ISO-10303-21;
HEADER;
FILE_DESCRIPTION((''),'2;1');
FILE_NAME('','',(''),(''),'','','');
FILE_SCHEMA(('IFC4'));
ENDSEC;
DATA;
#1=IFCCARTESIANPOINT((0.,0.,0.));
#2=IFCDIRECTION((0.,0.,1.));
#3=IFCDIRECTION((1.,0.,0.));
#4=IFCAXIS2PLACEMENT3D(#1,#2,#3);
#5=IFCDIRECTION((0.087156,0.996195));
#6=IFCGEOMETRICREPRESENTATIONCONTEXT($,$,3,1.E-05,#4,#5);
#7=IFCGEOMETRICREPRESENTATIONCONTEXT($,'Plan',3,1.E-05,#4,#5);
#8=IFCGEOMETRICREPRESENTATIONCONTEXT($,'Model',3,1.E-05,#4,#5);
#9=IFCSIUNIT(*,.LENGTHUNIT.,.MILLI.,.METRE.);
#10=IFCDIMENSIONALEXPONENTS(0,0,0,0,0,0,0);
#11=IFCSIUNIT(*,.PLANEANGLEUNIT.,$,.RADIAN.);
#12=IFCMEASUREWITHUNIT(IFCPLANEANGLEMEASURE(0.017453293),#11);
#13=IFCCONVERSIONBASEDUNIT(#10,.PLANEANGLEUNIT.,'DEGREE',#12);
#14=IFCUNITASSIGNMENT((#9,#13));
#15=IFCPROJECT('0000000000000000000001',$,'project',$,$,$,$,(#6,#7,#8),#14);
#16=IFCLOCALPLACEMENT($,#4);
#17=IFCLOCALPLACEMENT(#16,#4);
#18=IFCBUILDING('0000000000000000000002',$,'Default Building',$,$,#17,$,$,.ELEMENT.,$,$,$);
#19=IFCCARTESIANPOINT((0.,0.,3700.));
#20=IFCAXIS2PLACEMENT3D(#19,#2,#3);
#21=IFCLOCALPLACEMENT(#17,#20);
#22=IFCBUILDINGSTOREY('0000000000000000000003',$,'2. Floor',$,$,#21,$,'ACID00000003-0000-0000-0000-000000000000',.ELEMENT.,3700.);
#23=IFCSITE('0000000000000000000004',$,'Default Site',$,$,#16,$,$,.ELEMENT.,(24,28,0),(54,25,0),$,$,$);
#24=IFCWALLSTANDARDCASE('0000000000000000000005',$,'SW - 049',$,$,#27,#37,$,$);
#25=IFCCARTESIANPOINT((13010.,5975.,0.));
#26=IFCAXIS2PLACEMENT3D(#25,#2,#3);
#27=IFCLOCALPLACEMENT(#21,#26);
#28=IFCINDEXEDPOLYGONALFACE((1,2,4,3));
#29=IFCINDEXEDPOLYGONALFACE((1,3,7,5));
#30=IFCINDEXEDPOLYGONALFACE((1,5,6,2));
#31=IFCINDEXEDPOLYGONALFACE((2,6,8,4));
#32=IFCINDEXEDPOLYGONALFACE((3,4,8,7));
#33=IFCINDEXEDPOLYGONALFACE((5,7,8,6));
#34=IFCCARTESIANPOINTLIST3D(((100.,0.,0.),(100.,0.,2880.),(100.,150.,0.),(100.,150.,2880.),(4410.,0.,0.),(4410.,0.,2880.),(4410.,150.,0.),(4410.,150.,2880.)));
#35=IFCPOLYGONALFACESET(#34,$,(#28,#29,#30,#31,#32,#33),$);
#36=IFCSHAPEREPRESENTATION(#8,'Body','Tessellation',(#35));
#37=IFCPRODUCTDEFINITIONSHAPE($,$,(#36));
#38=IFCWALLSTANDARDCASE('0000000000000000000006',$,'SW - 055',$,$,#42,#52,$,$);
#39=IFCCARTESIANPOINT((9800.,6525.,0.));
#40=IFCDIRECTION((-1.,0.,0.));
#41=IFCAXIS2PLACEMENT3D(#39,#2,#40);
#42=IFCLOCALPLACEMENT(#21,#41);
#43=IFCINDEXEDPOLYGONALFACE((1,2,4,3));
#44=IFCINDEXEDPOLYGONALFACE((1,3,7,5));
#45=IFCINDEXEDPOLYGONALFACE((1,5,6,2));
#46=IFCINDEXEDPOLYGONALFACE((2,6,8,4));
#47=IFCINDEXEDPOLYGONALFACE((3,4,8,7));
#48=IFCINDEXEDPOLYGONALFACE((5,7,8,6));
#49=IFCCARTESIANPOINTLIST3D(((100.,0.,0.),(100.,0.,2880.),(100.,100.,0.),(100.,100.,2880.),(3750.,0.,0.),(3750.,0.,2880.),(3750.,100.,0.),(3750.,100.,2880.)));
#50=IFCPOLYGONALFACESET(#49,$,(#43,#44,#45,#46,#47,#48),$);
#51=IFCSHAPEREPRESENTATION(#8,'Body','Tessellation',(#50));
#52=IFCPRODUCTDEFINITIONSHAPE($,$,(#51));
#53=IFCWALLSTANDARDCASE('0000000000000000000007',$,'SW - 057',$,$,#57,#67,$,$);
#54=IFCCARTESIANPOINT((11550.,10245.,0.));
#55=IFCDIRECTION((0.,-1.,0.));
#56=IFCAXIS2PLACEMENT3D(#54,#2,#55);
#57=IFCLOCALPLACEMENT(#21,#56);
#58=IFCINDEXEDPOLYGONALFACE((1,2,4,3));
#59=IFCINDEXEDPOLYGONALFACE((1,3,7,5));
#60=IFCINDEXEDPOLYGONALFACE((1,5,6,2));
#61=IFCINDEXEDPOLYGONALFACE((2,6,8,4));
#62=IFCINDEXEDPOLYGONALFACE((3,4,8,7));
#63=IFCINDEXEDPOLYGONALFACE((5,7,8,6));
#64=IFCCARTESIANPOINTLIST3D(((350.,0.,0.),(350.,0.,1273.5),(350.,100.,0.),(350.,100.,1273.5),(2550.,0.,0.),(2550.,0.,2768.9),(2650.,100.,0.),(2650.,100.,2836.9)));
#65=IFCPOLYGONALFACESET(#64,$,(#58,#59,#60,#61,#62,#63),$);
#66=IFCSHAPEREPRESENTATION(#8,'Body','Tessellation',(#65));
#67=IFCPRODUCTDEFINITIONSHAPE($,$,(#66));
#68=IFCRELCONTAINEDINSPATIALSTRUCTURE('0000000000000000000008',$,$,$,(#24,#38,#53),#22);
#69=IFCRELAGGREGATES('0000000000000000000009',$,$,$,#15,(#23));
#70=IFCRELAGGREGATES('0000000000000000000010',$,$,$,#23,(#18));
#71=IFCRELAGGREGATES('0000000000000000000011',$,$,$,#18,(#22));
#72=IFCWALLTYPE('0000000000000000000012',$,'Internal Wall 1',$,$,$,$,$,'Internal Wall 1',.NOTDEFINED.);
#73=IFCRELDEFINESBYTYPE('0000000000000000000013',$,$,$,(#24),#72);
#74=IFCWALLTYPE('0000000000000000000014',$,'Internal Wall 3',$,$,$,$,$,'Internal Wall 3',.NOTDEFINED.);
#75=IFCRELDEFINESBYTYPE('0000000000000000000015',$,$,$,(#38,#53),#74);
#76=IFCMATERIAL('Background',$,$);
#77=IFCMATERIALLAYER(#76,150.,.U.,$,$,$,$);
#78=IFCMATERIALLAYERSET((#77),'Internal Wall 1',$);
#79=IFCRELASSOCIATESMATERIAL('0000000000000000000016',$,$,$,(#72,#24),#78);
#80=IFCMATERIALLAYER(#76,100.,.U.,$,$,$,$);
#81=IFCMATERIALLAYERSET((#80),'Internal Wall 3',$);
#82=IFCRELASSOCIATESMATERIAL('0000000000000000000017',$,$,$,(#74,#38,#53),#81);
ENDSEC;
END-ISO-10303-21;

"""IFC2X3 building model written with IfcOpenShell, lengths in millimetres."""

from ifc_helpers import new_model, entity, si_unit, converted_unit, direction, frame, origin_with_axes, place, context, project, spatial, polyline, outline, extrude, clip, halfspace, material, layer, layer_set, layer_usage, type_object, element, save


model = new_model("IFC2X3")

# Units and contexts
context_of_model = context(None, 3, precision=1e-05, world=origin_with_axes(), true_north=direction((0.087156, 0.996195)))
plan_context = context("Plan", 3, precision=1e-05, world=origin_with_axes(), true_north=direction((0.087156, 0.996195)))
model_context = context("Model", 3, precision=1e-05, world=origin_with_axes(), true_north=direction((0.087156, 0.996195)))
ifc_project = project(units=[si_unit("LENGTHUNIT", "METRE", prefix="MILLI"), converted_unit("PLANEANGLEUNIT", "DEGREE", entity("IfcPlaneAngleMeasure", 0.017453293), si_unit("PLANEANGLEUNIT", "RADIAN"), dimensions=[0, 0, 0, 0, 0, 0, 0])], contexts=[context_of_model, plan_context, model_context])

# Site, building, storey
site_placement = place(None, origin_with_axes())
site = spatial("IfcSite", under=ifc_project, at=site_placement, Name="Default Site", CompositionType="ELEMENT", RefLatitude=(24, 28, 0), RefLongitude=(54, 25, 0))
building_placement = place(site_placement, origin_with_axes())
building = spatial("IfcBuilding", under=site, at=building_placement, Name="Default Building", CompositionType="ELEMENT")
storey_placement = place(building_placement, frame((0.0, 0.0, 3700.0), z_axis=(0.0, 0.0, 1.0), x_axis=(1.0, 0.0, 0.0)))
storey = spatial("IfcBuildingStorey", under=building, at=storey_placement, Name="2. Floor", LongName="ACID00000003-0000-0000-0000-000000000000", CompositionType="ELEMENT", Elevation=3700.0)

# Shared definitions
ifc_material = material(Name="Background")

# Wall
ifc_layer_1 = layer(ifc_material, 150.0, ventilated="UNKNOWN")
ifc_layer_set_1 = layer_set([ifc_layer_1], Name="Internal Wall 1")
ifc_layer_usage_1 = layer_usage(ifc_layer_set_1, "AXIS2", "POSITIVE", 0.0)
wall_type_1 = type_object("IfcWallType", Name="Internal Wall 1", ElementType="Internal Wall 1", PredefinedType="NOTDEFINED", material=ifc_layer_set_1)
wall_1_placement = place(storey_placement, frame((13010.0, 5975.0, 0.0), z_axis=(0.0, 0.0, 1.0), x_axis=(1.0, 0.0, 0.0)))
element("IfcWallStandardCase", 1, at=wall_1_placement, inside=storey, type_object=wall_type_1, material=ifc_layer_usage_1, Name="SW - 049", context=model_context, shape_type="SweptSolid", body=[
    extrude(outline(polyline([(100.0, 0.0), (4410.0, 0.0), (4410.0, 150.0), (100.0, 150.0), (100.0, 0.0)])), origin_with_axes(), (0.0, 0.0, 1.0), 2880.0),
])
ifc_layer_2 = layer(ifc_material, 100.0, ventilated="UNKNOWN")
ifc_layer_set_2 = layer_set([ifc_layer_2], Name="Internal Wall 3")
wall_type_2 = type_object("IfcWallType", Name="Internal Wall 3", ElementType="Internal Wall 3", PredefinedType="NOTDEFINED", material=ifc_layer_set_2)

# Wall
ifc_layer_usage_2 = layer_usage(ifc_layer_set_2, "AXIS2", "POSITIVE", 0.0)
wall_2_placement = place(storey_placement, frame((9800.0, 6525.0, 0.0), z_axis=(0.0, 0.0, 1.0), x_axis=(-1.0, 0.0, 0.0)))
element("IfcWallStandardCase", 2, at=wall_2_placement, inside=storey, type_object=wall_type_2, material=ifc_layer_usage_2, Name="SW - 055", context=model_context, shape_type="SweptSolid", body=[
    extrude(outline(polyline([(100.0, 0.0), (3750.0, 0.0), (3750.0, 100.0), (100.0, 100.0), (100.0, 0.0)])), origin_with_axes(), (0.0, 0.0, 1.0), 2880.0),
])

# Wall
ifc_layer_usage_3 = layer_usage(ifc_layer_set_2, "AXIS2", "POSITIVE", 0.0)
wall_3_placement = place(storey_placement, frame((11550.0, 10245.0, 0.0), z_axis=(0.0, 0.0, 1.0), x_axis=(0.0, -1.0, 0.0)))
element("IfcWallStandardCase", 3, at=wall_3_placement, inside=storey, type_object=wall_type_2, material=ifc_layer_usage_3, Name="SW - 057", context=model_context, shape_type="Clipping", body=[
    clip(clip(extrude(outline(polyline([(350.0, 0.0), (2550.0, 0.0), (2650.0, 100.0), (350.0, 100.0), (350.0, 0.0)])), origin_with_axes(), (0.0, 0.0, 1.0), 2836.9), halfspace(frame((-481.5, 0.0, 708.4), z_axis=(-0.562142, 0.0, 0.827041), x_axis=(0.0, 1.0, 0.0)), False)), halfspace(frame((-481.5, 0.0, 708.4), z_axis=(-0.562142, 0.0, 0.827041), x_axis=(0.0, 1.0, 0.0)), False)),
])

save(model, "model.ifc")
